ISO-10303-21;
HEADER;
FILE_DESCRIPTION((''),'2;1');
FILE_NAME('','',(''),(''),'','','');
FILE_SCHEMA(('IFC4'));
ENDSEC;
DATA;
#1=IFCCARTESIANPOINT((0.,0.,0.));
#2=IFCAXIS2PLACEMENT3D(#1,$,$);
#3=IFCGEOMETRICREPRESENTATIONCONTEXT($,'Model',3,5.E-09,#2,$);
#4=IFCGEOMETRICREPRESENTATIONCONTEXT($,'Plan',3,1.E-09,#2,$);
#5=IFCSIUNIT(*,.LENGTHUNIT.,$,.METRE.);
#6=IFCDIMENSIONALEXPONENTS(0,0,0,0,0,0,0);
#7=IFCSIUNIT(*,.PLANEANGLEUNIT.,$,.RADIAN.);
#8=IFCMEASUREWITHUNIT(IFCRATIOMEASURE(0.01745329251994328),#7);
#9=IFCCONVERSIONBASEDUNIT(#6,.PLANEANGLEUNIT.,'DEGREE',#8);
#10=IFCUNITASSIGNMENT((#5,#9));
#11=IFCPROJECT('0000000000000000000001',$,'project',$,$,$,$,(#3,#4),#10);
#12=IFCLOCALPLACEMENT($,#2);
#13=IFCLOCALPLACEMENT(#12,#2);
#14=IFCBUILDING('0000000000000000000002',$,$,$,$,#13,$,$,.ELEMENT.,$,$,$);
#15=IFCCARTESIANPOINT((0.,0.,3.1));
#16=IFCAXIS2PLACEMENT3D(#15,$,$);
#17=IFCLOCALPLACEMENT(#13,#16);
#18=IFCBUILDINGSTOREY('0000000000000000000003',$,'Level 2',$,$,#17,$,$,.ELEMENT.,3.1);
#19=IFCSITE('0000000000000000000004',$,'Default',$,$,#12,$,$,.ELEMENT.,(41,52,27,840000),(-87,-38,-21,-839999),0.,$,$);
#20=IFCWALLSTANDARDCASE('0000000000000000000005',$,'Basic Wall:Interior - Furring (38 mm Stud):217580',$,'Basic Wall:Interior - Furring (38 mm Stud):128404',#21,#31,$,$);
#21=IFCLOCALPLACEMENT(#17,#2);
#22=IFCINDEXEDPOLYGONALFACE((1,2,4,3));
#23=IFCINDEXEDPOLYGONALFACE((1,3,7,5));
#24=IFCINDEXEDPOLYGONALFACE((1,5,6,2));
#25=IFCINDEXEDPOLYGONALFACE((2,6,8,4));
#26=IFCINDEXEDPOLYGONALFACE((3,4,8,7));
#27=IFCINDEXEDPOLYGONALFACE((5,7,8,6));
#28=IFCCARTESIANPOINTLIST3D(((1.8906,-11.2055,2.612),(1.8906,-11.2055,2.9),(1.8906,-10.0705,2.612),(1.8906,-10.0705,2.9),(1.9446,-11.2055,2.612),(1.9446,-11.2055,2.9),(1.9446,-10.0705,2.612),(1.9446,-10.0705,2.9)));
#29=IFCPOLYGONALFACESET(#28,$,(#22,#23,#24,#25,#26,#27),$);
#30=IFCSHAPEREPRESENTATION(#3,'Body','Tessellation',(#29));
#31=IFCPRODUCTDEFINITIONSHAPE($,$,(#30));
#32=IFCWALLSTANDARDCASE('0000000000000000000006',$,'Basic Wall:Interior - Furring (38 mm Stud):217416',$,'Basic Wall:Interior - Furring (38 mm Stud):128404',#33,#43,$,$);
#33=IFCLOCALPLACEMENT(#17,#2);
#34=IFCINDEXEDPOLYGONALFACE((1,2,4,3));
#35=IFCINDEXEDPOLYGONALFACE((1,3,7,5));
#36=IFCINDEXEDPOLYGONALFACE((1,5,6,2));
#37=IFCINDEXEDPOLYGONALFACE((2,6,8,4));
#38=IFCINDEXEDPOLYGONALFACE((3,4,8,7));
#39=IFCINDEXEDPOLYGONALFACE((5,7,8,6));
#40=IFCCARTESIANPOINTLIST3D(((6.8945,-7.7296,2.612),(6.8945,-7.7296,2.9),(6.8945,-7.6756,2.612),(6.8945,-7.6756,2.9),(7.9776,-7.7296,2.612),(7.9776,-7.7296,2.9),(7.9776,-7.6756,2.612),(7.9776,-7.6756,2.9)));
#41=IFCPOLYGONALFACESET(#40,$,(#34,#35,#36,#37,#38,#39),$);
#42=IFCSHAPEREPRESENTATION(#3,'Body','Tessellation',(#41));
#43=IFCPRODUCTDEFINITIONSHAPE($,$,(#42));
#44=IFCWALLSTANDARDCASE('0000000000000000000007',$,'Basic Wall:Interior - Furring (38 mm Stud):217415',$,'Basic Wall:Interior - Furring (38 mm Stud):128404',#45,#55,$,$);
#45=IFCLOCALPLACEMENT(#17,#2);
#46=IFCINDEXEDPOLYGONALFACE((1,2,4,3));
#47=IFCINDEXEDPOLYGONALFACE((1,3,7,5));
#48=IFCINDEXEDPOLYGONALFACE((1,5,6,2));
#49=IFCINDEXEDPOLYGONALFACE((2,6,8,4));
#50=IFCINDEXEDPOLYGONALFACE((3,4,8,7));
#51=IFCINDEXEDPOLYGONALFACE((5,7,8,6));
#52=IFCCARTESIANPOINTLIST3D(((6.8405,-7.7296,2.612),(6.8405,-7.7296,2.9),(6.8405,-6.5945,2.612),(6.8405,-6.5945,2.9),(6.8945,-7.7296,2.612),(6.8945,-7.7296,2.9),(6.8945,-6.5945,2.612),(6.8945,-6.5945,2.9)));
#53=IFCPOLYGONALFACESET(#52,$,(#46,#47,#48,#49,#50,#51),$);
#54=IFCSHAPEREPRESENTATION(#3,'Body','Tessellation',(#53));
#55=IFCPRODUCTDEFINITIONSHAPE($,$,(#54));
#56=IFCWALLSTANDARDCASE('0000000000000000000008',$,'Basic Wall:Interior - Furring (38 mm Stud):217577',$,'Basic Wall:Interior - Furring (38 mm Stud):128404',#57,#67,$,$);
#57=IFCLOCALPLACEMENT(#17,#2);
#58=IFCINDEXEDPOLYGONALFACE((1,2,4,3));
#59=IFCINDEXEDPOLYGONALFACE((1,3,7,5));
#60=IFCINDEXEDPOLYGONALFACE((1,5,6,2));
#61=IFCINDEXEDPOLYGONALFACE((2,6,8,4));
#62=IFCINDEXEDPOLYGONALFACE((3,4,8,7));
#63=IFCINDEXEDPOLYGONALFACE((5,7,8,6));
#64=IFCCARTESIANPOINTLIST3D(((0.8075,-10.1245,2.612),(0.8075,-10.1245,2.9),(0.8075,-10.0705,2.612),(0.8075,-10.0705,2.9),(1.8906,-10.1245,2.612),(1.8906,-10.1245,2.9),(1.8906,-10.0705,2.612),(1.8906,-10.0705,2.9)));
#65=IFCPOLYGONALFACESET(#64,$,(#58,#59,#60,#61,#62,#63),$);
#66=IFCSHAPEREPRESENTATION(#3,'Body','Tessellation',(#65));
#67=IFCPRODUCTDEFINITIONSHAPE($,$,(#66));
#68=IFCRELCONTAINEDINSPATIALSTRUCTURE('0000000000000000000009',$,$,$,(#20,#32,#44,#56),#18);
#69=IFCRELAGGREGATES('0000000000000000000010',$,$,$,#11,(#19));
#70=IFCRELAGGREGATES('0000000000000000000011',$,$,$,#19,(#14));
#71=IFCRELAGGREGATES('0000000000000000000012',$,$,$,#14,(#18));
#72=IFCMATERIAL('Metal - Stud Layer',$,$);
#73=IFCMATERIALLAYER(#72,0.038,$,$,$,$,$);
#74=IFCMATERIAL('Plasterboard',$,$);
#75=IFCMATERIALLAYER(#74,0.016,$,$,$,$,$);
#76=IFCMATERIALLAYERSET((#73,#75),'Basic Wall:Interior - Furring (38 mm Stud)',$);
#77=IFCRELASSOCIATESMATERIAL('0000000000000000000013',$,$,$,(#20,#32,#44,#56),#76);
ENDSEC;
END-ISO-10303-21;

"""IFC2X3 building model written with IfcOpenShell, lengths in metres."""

from ifc_helpers import new_model, entity, si_unit, converted_unit, frame, frame_2d, origin, place, context, project, spatial, rectangle, extrude, material, layer, layer_set, layer_usage, element, save


model = new_model("IFC2X3")

# Units and contexts
model_context = context("Model", 3, precision=5e-09, world=origin())
plan_context = context("Plan", 3, precision=1e-09, world=origin())
ifc_project = project(units=[si_unit("LENGTHUNIT", "METRE"), converted_unit("PLANEANGLEUNIT", "DEGREE", entity("IfcRatioMeasure", 0.01745329251994328), si_unit("PLANEANGLEUNIT", "RADIAN"), dimensions=[0, 0, 0, 0, 0, 0, 0])], contexts=[model_context, plan_context])

# Site, building, storey
site_placement = place(None, origin())
site = spatial("IfcSite", under=ifc_project, at=site_placement, Name="Default", CompositionType="ELEMENT", RefLatitude=(41, 52, 27, 840000), RefLongitude=(-87, -38, -21, -839999), RefElevation=0.0)
building_placement = place(site_placement, origin())
building = spatial("IfcBuilding", under=site, at=building_placement, CompositionType="ELEMENT")
storey_placement = place(building_placement, frame((0.0, 0.0, 3.1)))
storey = spatial("IfcBuildingStorey", under=building, at=storey_placement, Name="Level 2", CompositionType="ELEMENT", Elevation=3.1)

# Shared definitions
ifc_material_1 = material(Name="Plasterboard")
ifc_material_2 = material(Name="Metal - Stud Layer")

# Walls
ifc_layer_1 = layer(ifc_material_2, 0.038)
ifc_layer_2 = layer(ifc_material_1, 0.016)
ifc_layer_set_1 = layer_set([ifc_layer_1, ifc_layer_2], Name="Basic Wall:Interior - Furring (38 mm Stud)")
ifc_layer_usage_1 = layer_usage(ifc_layer_set_1, "AXIS2", "NEGATIVE", 0.027)
wall_1_placement = place(storey_placement, frame((1.9176, -10.0705, 2.612), z_axis=(0.0, 0.0, 1.0), x_axis=(0.0, -1.0, 0.0)))
element("IfcWallStandardCase", 1, at=wall_1_placement, inside=storey, material=ifc_layer_usage_1, Name="Basic Wall:Interior - Furring (38 mm Stud):217580", ObjectType="Basic Wall:Interior - Furring (38 mm Stud):128404", context=model_context, shape_type="SweptSolid", body=[
    extrude(rectangle(XDim=1.1351, YDim=0.054, at=frame_2d((0.5675, 0.0), x_axis=(-1.0, 0.0))), origin(), (0.0, 0.0, 1.0), 0.288),
])
wall_2_placement = place(storey_placement, frame((7.9776, -7.7026, 2.612), z_axis=(0.0, 0.0, 1.0), x_axis=(-1.0, 0.0, 0.0)))
element("IfcWallStandardCase", 2, at=wall_2_placement, inside=storey, material=ifc_layer_usage_1, Name="Basic Wall:Interior - Furring (38 mm Stud):217416", ObjectType="Basic Wall:Interior - Furring (38 mm Stud):128404", context=model_context, shape_type="SweptSolid", body=[
    extrude(rectangle(XDim=1.0831, YDim=0.054, at=frame_2d((0.5416, 0.0), x_axis=(-1.0, 0.0))), origin(), (0.0, 0.0, 1.0), 0.288),
])
wall_3_placement = place(storey_placement, frame((6.8675, -7.7296, 2.612), z_axis=(0.0, 0.0, 1.0), x_axis=(0.0, 1.0, 0.0)))
element("IfcWallStandardCase", 3, at=wall_3_placement, inside=storey, material=ifc_layer_usage_1, Name="Basic Wall:Interior - Furring (38 mm Stud):217415", ObjectType="Basic Wall:Interior - Furring (38 mm Stud):128404", context=model_context, shape_type="SweptSolid", body=[
    extrude(rectangle(XDim=1.1351, YDim=0.054, at=frame_2d((0.5675, 0.0), x_axis=(-1.0, 0.0))), origin(), (0.0, 0.0, 1.0), 0.288),
])
wall_4_placement = place(storey_placement, frame((0.8075, -10.0975, 2.612)))
element("IfcWallStandardCase", 4, at=wall_4_placement, inside=storey, material=ifc_layer_usage_1, Name="Basic Wall:Interior - Furring (38 mm Stud):217577", ObjectType="Basic Wall:Interior - Furring (38 mm Stud):128404", context=model_context, shape_type="SweptSolid", body=[
    extrude(rectangle(XDim=1.0831, YDim=0.054, at=frame_2d((0.5415, 0.0), x_axis=(-1.0, 0.0))), origin(), (0.0, 0.0, 1.0), 0.288),
])

save(model, "model.ifc")
